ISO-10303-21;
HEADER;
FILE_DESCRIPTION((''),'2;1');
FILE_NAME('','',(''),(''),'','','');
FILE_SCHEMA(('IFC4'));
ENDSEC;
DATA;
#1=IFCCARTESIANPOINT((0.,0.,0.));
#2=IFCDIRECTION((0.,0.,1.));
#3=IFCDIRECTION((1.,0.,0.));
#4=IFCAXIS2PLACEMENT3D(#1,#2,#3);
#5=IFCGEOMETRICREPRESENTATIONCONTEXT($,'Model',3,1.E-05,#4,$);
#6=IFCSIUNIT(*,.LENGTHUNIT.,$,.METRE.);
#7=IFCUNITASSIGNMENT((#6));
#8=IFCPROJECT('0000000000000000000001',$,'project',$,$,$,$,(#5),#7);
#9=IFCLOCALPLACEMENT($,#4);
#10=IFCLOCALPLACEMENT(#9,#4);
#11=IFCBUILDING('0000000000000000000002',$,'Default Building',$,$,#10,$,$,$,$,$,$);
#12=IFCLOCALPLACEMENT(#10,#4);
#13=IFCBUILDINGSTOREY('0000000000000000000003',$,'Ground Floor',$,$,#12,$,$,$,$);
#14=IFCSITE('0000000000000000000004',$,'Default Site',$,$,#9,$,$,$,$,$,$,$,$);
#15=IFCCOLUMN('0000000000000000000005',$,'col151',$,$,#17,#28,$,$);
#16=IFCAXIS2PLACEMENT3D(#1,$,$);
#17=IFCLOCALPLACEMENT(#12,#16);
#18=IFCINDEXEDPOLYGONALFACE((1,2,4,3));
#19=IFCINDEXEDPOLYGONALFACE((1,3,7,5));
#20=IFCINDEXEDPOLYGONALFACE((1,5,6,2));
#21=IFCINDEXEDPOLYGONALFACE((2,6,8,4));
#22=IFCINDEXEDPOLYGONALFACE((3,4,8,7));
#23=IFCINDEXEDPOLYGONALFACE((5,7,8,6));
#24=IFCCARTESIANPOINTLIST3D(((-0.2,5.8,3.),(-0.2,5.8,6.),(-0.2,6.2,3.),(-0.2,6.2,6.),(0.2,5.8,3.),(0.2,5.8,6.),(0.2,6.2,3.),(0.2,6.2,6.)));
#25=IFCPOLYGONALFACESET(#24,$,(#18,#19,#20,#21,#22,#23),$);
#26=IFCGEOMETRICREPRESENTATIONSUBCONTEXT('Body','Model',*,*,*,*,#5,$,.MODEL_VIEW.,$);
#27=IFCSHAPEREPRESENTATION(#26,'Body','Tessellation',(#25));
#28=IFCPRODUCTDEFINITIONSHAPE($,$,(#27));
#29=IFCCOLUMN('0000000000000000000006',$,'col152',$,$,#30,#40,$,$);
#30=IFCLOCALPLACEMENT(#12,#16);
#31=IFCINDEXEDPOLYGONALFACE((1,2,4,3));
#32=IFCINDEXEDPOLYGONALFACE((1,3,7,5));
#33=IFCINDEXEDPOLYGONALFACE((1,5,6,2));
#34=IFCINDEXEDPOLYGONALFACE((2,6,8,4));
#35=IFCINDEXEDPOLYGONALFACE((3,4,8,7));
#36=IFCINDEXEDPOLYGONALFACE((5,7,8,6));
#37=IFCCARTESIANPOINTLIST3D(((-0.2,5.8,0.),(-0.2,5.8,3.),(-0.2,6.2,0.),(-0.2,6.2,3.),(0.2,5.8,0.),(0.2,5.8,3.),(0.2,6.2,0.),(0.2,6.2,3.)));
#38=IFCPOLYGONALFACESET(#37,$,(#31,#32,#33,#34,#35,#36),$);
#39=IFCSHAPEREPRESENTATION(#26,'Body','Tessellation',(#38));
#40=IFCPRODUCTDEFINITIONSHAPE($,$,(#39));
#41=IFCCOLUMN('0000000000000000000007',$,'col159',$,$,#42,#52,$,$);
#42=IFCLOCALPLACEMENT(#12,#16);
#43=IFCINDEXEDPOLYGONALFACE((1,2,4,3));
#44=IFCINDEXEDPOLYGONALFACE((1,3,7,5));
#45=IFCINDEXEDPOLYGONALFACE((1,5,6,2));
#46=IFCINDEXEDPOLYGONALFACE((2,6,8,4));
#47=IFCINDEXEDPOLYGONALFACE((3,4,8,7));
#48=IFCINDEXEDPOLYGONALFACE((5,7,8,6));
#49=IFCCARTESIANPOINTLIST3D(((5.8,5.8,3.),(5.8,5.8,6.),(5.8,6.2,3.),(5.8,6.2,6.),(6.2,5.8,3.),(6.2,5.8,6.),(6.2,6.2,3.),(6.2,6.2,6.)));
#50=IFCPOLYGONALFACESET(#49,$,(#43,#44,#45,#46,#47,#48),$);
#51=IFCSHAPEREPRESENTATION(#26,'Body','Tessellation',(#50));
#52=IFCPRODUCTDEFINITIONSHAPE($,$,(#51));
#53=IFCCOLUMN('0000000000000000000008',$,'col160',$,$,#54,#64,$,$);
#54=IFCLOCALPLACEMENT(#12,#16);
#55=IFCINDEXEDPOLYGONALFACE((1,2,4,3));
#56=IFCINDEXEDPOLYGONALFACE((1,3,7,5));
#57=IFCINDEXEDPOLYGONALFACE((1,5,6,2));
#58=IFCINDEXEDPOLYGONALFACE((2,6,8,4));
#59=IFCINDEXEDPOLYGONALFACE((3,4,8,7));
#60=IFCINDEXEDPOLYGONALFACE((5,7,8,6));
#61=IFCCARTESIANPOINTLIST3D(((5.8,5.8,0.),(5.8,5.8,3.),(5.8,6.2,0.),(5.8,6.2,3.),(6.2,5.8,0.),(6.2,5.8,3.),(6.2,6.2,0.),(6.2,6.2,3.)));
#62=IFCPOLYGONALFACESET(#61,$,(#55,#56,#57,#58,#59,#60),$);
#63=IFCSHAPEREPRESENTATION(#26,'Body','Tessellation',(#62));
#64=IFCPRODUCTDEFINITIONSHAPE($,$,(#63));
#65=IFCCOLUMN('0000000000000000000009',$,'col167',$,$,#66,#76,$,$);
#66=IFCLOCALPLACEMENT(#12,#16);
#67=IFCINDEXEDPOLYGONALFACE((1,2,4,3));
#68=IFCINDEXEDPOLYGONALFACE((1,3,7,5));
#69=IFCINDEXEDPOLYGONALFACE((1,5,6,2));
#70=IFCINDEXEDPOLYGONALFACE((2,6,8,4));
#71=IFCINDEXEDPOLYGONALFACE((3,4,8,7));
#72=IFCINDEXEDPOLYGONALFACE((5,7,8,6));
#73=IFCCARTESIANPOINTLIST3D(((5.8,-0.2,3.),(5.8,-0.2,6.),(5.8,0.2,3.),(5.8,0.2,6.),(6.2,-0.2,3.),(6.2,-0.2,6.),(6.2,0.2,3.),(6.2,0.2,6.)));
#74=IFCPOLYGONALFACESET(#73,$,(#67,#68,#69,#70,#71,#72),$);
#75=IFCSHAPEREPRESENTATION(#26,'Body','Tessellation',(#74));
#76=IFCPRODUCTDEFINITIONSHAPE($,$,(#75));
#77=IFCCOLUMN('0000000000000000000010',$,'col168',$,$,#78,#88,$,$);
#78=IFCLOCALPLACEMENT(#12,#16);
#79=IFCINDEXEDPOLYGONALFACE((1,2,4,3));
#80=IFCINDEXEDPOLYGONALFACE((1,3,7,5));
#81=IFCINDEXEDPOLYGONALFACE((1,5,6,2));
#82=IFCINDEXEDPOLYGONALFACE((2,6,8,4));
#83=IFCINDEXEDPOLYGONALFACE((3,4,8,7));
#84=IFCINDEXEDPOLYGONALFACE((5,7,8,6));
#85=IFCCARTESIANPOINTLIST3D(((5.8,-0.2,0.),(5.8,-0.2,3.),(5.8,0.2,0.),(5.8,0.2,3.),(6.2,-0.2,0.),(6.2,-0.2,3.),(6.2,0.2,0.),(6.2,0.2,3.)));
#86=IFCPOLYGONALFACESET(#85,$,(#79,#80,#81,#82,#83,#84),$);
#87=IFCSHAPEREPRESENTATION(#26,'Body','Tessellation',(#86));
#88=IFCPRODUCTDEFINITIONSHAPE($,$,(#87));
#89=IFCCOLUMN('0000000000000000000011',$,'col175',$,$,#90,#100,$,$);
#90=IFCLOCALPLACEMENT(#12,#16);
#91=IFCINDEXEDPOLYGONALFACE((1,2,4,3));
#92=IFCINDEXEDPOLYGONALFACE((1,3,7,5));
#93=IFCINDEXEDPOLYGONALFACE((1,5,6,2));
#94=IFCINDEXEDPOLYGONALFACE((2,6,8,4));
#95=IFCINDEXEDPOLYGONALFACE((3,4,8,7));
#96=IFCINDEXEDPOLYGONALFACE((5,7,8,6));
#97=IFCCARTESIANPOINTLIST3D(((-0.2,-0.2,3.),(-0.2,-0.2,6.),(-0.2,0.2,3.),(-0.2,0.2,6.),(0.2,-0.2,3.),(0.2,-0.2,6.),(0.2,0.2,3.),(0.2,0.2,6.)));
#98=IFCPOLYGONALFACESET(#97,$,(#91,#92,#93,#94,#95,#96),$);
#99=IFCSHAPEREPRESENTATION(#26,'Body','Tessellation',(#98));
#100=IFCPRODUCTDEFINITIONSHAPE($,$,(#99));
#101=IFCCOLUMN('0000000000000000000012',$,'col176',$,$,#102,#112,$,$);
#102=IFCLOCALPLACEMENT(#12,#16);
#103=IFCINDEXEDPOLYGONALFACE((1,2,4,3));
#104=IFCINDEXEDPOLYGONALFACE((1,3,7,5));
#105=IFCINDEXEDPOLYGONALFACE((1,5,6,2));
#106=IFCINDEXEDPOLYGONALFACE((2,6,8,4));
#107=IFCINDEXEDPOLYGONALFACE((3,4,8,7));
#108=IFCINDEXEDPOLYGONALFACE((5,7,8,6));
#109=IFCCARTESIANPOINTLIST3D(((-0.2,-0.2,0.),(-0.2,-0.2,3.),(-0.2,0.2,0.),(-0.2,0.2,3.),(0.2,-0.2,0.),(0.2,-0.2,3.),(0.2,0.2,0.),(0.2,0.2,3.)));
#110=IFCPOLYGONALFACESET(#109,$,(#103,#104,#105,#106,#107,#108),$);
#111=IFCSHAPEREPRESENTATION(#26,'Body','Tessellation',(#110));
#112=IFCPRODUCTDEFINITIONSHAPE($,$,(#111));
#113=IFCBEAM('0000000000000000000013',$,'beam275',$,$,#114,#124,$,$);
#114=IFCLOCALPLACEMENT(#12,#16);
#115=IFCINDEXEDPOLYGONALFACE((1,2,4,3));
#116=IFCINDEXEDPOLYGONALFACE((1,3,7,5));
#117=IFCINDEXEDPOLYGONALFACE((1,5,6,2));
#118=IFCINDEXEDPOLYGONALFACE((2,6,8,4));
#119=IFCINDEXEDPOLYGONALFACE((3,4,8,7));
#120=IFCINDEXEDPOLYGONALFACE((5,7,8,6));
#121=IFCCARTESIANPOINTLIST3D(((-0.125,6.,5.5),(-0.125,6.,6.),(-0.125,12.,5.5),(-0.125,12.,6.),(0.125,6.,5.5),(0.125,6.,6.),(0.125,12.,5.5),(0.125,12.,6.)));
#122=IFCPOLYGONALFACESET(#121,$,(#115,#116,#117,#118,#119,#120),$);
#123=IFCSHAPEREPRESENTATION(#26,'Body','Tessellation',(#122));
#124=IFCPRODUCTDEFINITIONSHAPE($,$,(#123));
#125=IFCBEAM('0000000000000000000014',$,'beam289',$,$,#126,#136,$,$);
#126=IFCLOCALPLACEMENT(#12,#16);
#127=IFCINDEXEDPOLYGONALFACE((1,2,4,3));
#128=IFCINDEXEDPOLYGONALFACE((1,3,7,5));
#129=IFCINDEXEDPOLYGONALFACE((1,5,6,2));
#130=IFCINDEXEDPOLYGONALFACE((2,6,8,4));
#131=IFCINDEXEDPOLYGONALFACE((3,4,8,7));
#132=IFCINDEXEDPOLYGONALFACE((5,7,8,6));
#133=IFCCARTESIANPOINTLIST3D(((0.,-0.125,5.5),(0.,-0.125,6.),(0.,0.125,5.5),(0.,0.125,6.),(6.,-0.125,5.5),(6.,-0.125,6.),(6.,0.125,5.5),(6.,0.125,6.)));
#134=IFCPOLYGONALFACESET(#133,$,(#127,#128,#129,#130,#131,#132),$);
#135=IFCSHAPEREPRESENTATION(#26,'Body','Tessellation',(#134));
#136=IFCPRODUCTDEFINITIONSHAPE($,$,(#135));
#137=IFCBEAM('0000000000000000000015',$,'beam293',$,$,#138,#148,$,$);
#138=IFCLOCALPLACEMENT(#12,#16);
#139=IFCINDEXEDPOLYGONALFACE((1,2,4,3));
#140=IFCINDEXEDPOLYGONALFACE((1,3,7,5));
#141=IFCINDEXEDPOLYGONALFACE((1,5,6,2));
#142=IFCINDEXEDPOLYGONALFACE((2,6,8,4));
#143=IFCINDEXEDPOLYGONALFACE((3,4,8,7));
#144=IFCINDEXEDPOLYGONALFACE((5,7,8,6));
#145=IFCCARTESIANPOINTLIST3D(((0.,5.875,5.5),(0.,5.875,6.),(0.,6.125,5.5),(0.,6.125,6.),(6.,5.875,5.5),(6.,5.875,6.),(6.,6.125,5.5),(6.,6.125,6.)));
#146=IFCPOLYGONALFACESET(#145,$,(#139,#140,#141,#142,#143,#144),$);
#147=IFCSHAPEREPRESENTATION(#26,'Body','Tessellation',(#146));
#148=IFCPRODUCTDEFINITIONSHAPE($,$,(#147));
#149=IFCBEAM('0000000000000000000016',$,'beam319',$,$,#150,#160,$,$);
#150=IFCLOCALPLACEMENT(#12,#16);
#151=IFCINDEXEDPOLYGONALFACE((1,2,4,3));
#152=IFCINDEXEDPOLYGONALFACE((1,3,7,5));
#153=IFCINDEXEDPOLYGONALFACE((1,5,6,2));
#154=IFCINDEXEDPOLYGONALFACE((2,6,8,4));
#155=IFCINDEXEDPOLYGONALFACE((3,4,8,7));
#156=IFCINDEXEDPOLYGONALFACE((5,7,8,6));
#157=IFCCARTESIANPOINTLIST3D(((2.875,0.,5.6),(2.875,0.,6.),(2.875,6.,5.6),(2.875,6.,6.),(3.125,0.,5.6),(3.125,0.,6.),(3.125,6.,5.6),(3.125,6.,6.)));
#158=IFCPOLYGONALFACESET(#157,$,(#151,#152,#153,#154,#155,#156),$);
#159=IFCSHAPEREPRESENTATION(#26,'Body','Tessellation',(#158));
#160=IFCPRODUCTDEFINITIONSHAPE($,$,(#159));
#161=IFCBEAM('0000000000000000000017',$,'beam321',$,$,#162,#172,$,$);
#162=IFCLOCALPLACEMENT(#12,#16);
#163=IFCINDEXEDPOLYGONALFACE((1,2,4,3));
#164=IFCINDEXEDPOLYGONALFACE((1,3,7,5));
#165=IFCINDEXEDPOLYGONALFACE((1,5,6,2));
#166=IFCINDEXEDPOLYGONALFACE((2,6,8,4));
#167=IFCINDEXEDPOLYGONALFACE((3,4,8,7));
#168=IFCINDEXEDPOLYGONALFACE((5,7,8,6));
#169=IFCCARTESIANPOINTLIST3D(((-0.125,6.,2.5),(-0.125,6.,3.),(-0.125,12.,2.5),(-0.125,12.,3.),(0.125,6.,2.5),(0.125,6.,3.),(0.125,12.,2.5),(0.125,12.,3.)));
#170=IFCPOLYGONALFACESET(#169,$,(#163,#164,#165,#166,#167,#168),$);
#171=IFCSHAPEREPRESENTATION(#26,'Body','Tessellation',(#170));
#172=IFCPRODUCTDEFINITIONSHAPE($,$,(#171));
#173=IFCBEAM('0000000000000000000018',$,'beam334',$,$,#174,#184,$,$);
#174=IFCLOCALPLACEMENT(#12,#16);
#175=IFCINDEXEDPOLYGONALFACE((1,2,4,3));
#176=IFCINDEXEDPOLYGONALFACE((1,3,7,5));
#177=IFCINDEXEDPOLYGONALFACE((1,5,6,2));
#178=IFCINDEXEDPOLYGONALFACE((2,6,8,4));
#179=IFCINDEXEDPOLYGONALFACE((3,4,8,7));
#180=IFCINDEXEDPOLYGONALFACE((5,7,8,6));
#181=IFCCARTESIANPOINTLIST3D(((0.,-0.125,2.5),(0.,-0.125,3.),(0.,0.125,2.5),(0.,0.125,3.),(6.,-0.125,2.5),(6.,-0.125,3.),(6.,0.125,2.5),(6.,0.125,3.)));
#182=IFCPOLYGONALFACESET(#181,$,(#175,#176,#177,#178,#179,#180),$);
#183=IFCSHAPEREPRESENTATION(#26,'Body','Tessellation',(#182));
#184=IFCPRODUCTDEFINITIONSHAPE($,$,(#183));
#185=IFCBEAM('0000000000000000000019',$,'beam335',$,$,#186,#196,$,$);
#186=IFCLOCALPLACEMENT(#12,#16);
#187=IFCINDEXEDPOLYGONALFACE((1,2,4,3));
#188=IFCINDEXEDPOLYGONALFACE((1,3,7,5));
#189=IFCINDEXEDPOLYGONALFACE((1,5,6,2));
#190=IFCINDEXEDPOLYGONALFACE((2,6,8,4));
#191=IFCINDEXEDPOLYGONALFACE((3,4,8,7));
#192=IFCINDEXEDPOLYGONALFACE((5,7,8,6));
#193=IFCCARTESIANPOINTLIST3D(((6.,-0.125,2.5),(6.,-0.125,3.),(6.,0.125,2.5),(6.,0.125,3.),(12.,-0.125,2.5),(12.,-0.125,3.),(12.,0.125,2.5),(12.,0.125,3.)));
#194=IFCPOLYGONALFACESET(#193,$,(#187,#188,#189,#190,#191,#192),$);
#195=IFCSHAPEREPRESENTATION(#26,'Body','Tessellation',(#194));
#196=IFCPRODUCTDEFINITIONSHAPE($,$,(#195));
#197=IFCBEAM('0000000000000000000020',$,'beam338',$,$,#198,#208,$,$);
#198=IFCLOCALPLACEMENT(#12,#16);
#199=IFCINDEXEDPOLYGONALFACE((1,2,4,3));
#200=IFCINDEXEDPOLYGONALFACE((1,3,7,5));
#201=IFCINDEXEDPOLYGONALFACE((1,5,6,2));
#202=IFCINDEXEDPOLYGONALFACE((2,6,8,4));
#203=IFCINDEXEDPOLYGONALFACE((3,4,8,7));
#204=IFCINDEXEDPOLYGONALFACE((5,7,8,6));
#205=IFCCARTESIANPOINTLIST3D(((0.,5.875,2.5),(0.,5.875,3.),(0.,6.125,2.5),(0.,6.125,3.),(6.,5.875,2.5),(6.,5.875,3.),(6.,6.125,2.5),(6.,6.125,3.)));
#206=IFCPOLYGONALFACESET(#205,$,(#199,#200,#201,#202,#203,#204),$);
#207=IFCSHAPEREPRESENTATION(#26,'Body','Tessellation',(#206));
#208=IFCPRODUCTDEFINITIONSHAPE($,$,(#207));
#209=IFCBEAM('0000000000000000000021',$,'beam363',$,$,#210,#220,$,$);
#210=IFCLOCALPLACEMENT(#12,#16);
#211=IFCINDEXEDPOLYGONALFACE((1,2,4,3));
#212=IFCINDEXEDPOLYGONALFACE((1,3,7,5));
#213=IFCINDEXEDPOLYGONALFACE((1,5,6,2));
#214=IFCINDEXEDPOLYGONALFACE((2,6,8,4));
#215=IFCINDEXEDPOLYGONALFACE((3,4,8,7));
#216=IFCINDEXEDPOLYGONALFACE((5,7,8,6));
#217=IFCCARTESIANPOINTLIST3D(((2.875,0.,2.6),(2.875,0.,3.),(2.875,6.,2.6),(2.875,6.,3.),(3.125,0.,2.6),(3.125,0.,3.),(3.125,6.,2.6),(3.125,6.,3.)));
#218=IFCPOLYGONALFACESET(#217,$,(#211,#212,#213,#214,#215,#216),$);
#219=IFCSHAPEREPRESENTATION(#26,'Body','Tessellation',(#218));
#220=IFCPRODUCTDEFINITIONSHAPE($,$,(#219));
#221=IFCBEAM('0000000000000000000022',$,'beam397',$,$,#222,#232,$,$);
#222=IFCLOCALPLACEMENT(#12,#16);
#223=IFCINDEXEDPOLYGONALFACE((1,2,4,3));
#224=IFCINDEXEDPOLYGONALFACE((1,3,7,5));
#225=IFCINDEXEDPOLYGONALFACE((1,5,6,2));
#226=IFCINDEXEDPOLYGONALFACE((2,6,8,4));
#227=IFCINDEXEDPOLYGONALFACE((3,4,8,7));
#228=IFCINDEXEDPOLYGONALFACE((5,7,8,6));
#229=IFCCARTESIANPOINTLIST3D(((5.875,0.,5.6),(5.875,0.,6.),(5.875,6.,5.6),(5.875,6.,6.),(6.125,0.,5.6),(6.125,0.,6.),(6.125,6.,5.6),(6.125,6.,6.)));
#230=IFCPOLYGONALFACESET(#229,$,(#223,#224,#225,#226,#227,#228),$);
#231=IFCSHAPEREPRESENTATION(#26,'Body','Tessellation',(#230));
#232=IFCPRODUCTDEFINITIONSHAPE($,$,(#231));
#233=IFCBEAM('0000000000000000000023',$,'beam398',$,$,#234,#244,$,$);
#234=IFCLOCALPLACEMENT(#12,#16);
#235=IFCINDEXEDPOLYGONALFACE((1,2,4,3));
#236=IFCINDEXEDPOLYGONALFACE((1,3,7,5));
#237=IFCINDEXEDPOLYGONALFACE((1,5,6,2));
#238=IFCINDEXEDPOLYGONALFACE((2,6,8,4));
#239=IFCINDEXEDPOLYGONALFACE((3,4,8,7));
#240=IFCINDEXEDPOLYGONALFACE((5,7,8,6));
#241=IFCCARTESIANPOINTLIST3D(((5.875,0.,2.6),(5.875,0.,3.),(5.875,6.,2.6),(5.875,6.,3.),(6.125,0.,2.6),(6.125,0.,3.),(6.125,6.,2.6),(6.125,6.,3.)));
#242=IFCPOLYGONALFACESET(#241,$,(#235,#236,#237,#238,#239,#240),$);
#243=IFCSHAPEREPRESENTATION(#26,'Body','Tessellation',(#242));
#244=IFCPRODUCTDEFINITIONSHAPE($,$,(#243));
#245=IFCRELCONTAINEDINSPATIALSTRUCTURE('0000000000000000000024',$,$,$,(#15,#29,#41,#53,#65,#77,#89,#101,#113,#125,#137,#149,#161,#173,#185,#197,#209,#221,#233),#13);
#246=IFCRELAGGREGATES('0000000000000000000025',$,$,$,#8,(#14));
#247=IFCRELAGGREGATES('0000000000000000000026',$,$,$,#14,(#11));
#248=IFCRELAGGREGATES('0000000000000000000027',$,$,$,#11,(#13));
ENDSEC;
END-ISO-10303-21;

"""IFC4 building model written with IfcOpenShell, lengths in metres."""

from ifc_helpers import new_model, si_unit, frame, origin_with_axes, place, context, subcontext, project, spatial, indexed_curve, outline, extrude, element, save


model = new_model("IFC4")

# Units and contexts
model_context = context("Model", 3, precision=1e-05, world=origin_with_axes())
body_context = subcontext(model_context, "Body", "Model", "MODEL_VIEW")
ifc_project = project(units=[si_unit("LENGTHUNIT", "METRE")], contexts=[model_context])

# Site, building, storey
site_placement = place(None, origin_with_axes())
site = spatial("IfcSite", under=ifc_project, at=site_placement, Name="Default Site")
building_placement = place(site_placement, origin_with_axes())
building = spatial("IfcBuilding", under=site, at=building_placement, Name="Default Building")
storey_placement = place(building_placement, origin_with_axes())
storey = spatial("IfcBuildingStorey", under=building, at=storey_placement, Name="Ground Floor")

# Columns
for number, where, z_axis, x_axis, name in (
    (1, (-0.2, 5.8, 3.0), (0.0, 0.0, 1.0), (1.0, 0.0, 0.0), "col151"),
    (2, (-0.2, 5.8, 0.0), (0.0, 0.0, 1.0), (1.0, 0.0, 0.0), "col152"),
    (3, (5.8, 5.8, 3.0), (0.0, 0.0, 1.0), (1.0, 0.0, 0.0), "col159"),
    (4, (5.8, 5.8, 0.0), (0.0, 0.0, 1.0), (1.0, 0.0, 0.0), "col160"),
    (5, (5.8, -0.2, 3.0), (0.0, 0.0, 1.0), (1.0, 0.0, 0.0), "col167"),
    (6, (5.8, -0.2, 0.0), (0.0, 0.0, 1.0), (1.0, 0.0, 0.0), "col168"),
    (7, (-0.2, -0.2, 3.0), (0.0, 0.0, 1.0), (1.0, 0.0, 0.0), "col175"),
    (8, (-0.2, -0.2, 0.0), (0.0, 0.0, 1.0), (1.0, 0.0, 0.0), "col176"),
):
    element("IfcColumn", number, at=place(storey_placement, frame(where, z_axis=z_axis, x_axis=x_axis)), inside=storey, Name=name, context=body_context, shape_type="SweptSolid", body=[
        extrude(outline(indexed_curve([(0.0, 0.0), (0.0, 0.4), (0.4, 0.4), (0.4, 0.0), (0.0, 0.0)], self_intersect=False)), origin_with_axes(), (0.0, 0.0, 1.0), 3.0),
    ])

# Beams
for number, where, z_axis, x_axis, name in (
    (9, (0.125, 6.0, 5.5), (0.0, 0.0, 1.0), (0.0, 1.0, 0.0), "beam275"),
    (10, (0.0, -0.125, 5.5), (0.0, 0.0, 1.0), (1.0, 0.0, 0.0), "beam289"),
    (11, (0.0, 5.875, 5.5), (0.0, 0.0, 1.0), (1.0, 0.0, 0.0), "beam293"),
):
    element("IfcBeam", number, at=place(storey_placement, frame(where, z_axis=z_axis, x_axis=x_axis)), inside=storey, Name=name, context=body_context, shape_type="SweptSolid", body=[
        extrude(outline(indexed_curve([(0.0, 0.0), (0.0, 0.25), (6.0, 0.25), (6.0, 0.0), (0.0, 0.0)], self_intersect=False)), origin_with_axes(), (0.0, 0.0, 1.0), 0.5),
    ])
beam_placement = place(storey_placement, frame((2.875, 6.0, 5.6), z_axis=(0.0, 0.0, 1.0), x_axis=(0.0, -1.0, 0.0)))
element("IfcBeam", 12, at=beam_placement, inside=storey, Name="beam319", context=body_context, shape_type="SweptSolid", body=[
    extrude(outline(indexed_curve([(0.0, 0.0), (0.0, 0.25), (6.0, 0.25), (6.0, 0.0), (0.0, 0.0)], self_intersect=False)), origin_with_axes(), (0.0, 0.0, 1.0), 0.4),
])
for number, where, z_axis, x_axis, name in (
    (13, (0.125, 6.0, 2.5), (0.0, 0.0, 1.0), (0.0, 1.0, 0.0), "beam321"),
    (14, (0.0, -0.125, 2.5), (0.0, 0.0, 1.0), (1.0, 0.0, 0.0), "beam334"),
    (15, (6.0, -0.125, 2.5), (0.0, 0.0, 1.0), (1.0, 0.0, 0.0), "beam335"),
    (16, (0.0, 5.875, 2.5), (0.0, 0.0, 1.0), (1.0, 0.0, 0.0), "beam338"),
):
    element("IfcBeam", number, at=place(storey_placement, frame(where, z_axis=z_axis, x_axis=x_axis)), inside=storey, Name=name, context=body_context, shape_type="SweptSolid", body=[
        extrude(outline(indexed_curve([(0.0, 0.0), (0.0, 0.25), (6.0, 0.25), (6.0, 0.0), (0.0, 0.0)], self_intersect=False)), origin_with_axes(), (0.0, 0.0, 1.0), 0.5),
    ])
for number, where, z_axis, x_axis, name in (
    (17, (2.875, 6.0, 2.6), (0.0, 0.0, 1.0), (0.0, -1.0, 0.0), "beam363"),
    (18, (5.875, 6.0, 5.6), (0.0, 0.0, 1.0), (0.0, -1.0, 0.0), "beam397"),
    (19, (5.875, 6.0, 2.6), (0.0, 0.0, 1.0), (0.0, -1.0, 0.0), "beam398"),
):
    element("IfcBeam", number, at=place(storey_placement, frame(where, z_axis=z_axis, x_axis=x_axis)), inside=storey, Name=name, context=body_context, shape_type="SweptSolid", body=[
        extrude(outline(indexed_curve([(0.0, 0.0), (0.0, 0.25), (6.0, 0.25), (6.0, 0.0), (0.0, 0.0)], self_intersect=False)), origin_with_axes(), (0.0, 0.0, 1.0), 0.4),
    ])

save(model, "model.ifc")
